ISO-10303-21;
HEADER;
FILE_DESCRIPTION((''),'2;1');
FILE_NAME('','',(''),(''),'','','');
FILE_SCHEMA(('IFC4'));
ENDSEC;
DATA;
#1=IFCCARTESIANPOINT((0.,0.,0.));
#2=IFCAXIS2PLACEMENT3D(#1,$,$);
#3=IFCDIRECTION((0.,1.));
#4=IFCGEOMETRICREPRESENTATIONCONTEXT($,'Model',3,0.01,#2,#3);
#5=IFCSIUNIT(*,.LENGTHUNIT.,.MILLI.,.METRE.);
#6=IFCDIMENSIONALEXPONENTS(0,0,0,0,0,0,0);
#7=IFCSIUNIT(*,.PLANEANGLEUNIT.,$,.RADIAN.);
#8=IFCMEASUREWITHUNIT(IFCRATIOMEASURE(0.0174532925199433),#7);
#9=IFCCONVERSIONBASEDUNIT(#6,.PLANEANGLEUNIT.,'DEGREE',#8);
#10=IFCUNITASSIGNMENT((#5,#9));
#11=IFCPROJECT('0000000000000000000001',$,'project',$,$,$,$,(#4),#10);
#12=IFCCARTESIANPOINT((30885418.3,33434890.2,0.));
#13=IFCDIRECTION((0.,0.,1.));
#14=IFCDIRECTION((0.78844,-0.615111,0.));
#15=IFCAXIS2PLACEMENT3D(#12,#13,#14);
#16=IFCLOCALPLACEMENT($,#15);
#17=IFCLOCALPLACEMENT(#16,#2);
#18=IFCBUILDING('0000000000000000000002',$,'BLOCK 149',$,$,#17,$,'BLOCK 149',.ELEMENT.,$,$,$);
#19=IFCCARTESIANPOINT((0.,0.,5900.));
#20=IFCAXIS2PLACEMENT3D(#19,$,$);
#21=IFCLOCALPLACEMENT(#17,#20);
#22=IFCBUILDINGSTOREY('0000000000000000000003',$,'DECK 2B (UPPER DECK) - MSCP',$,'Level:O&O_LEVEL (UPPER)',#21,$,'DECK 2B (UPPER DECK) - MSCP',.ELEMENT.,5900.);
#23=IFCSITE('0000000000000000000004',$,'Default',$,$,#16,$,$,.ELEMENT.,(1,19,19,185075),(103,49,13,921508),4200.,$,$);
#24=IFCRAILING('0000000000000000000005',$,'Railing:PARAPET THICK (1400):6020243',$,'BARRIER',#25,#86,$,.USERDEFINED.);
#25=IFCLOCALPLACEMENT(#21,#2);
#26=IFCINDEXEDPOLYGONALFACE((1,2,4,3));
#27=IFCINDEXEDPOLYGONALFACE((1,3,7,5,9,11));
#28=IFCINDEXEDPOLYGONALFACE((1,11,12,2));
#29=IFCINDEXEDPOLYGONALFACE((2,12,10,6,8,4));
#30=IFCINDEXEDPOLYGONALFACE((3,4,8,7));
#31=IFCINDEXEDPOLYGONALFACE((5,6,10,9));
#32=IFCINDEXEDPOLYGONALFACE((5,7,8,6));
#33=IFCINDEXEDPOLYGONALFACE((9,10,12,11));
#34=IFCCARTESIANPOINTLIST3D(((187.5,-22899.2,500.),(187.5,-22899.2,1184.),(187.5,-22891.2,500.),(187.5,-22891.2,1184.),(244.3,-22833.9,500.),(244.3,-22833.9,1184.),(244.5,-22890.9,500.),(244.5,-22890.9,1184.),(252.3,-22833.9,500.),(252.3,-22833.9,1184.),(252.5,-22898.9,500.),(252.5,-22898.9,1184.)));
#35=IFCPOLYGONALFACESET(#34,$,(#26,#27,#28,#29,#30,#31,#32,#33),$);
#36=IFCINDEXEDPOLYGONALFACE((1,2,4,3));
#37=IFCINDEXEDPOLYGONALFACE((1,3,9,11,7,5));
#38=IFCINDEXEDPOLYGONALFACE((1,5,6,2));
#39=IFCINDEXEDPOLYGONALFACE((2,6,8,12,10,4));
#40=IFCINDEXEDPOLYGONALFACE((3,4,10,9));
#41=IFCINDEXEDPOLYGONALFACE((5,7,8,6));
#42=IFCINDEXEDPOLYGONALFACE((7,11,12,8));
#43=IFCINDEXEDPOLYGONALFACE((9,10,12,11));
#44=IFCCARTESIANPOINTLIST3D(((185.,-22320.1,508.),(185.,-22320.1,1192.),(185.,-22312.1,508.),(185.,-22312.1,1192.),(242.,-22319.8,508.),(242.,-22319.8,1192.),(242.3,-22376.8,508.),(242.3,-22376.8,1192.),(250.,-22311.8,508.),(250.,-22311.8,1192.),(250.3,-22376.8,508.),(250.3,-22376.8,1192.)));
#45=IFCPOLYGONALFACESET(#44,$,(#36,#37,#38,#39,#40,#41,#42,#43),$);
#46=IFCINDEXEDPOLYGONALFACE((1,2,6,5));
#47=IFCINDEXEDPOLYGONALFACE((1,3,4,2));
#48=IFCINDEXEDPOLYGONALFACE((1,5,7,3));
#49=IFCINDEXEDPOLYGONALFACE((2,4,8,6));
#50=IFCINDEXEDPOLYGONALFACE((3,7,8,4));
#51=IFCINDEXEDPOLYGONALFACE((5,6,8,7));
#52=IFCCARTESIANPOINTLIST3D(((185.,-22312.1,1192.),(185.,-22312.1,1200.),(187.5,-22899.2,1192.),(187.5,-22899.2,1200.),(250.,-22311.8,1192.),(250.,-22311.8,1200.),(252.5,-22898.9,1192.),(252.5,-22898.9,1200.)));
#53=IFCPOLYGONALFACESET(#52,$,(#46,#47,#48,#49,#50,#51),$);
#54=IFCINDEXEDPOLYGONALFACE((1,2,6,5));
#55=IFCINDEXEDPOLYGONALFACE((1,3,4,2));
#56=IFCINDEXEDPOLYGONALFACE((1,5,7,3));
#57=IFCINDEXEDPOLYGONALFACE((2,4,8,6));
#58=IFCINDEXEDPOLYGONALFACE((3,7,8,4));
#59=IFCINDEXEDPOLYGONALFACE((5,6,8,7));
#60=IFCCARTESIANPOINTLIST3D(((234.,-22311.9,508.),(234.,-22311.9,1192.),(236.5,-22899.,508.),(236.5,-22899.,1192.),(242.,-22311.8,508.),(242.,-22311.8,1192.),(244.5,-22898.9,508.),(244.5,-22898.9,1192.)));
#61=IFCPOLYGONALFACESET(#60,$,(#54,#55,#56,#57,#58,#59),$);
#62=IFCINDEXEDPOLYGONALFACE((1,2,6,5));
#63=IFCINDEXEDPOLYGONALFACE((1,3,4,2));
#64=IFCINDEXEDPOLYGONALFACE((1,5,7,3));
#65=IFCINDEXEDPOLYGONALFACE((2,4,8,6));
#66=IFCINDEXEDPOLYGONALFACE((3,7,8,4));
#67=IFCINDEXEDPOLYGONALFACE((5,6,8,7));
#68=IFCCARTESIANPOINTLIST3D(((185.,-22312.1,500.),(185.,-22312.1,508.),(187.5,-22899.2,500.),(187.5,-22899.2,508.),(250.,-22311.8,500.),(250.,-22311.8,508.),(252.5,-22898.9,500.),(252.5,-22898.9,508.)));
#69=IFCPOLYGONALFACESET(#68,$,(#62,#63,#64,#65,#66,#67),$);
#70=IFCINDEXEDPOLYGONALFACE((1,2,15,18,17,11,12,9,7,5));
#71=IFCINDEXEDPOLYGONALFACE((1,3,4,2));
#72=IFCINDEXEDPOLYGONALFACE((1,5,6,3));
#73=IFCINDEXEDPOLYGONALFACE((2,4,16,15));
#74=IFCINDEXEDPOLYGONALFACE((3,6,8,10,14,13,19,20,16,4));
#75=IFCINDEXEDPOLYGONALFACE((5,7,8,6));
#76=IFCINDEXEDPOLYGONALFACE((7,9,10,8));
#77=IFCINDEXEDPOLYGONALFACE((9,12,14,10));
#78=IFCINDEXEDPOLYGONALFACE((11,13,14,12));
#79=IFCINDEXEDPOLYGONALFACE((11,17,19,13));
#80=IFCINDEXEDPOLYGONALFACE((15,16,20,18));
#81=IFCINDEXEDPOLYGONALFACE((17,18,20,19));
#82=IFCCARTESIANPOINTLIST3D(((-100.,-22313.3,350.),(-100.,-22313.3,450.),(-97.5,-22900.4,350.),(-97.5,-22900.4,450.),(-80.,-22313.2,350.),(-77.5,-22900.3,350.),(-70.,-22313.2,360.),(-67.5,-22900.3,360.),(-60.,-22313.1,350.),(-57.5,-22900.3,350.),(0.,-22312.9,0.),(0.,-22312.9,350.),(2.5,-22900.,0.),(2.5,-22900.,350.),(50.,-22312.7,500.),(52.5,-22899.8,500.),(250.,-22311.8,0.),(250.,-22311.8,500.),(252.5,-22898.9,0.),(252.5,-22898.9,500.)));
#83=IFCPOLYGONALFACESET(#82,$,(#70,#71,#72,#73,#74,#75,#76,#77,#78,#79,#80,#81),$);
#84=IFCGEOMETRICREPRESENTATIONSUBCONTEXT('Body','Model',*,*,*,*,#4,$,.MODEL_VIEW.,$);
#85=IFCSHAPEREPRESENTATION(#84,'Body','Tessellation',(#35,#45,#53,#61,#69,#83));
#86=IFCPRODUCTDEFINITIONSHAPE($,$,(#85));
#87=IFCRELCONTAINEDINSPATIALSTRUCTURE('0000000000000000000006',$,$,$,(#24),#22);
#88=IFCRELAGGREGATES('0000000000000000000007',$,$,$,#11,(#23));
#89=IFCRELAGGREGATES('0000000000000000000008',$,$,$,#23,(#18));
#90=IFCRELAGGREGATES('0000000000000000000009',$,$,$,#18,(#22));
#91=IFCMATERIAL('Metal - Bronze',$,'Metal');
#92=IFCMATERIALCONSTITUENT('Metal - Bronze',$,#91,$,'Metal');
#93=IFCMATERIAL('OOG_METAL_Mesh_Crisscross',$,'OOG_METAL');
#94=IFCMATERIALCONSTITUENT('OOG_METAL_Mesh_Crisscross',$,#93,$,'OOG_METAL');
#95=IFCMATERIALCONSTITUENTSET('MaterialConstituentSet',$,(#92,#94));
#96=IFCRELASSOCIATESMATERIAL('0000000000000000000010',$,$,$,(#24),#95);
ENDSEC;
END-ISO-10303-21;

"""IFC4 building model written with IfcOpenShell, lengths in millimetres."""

from ifc_helpers import new_model, entity, si_unit, converted_unit, direction, frame, origin, place, context, subcontext, project, spatial, indexed_curve, outline, extrude, material, constituent, constituent_set, element, save


model = new_model("IFC4")

# Units and contexts
model_context = context("Model", 3, precision=0.01, world=origin(), true_north=direction((0.0, 1.0)))
body_context = subcontext(model_context, "Body", "Model", "MODEL_VIEW")
ifc_project = project(units=[si_unit("LENGTHUNIT", "METRE", prefix="MILLI"), converted_unit("PLANEANGLEUNIT", "DEGREE", entity("IfcRatioMeasure", 0.0174532925199433), si_unit("PLANEANGLEUNIT", "RADIAN"), dimensions=[0, 0, 0, 0, 0, 0, 0])], contexts=[model_context])

# Site, building, storey
site_placement = place(None, frame((30885418.3, 33434890.2, 0.0), z_axis=(0.0, 0.0, 1.0), x_axis=(0.78844, -0.615111, 0.0)))
site = spatial("IfcSite", under=ifc_project, at=site_placement, Name="Default", CompositionType="ELEMENT", RefLatitude=(1, 19, 19, 185075), RefLongitude=(103, 49, 13, 921508), RefElevation=4200.0)
building_placement = place(site_placement, origin())
building = spatial("IfcBuilding", under=site, at=building_placement, Name="BLOCK 149", LongName="BLOCK 149", CompositionType="ELEMENT")
storey_placement = place(building_placement, frame((0.0, 0.0, 5900.0)))
storey = spatial("IfcBuildingStorey", under=building, at=storey_placement, Name="DECK 2B (UPPER DECK) - MSCP", ObjectType="Level:O&O_LEVEL (UPPER)", LongName="DECK 2B (UPPER DECK) - MSCP", CompositionType="ELEMENT", Elevation=5900.0)

# Railing
ifc_material_1 = material(Name="Metal - Bronze", Category="Metal")
ifc_material_2 = material(Name="OOG_METAL_Mesh_Crisscross", Category="OOG_METAL")
ifc_constituent_1 = constituent(ifc_material_1, Name="Metal - Bronze", Category="Metal")
ifc_constituent_2 = constituent(ifc_material_2, Name="OOG_METAL_Mesh_Crisscross", Category="OOG_METAL")
ifc_constituent_set_1 = constituent_set(constituents=[ifc_constituent_1, ifc_constituent_2], Name="MaterialConstituentSet")
railing_1_placement = place(storey_placement, origin())
element("IfcRailing", 1, at=railing_1_placement, inside=storey, material=ifc_constituent_set_1, Name="Railing:PARAPET THICK (1400):6020243", ObjectType="BARRIER", PredefinedType="USERDEFINED", context=body_context, shape_type="SweptSolid", body=[
    extrude(outline(indexed_curve([(16.3, -40.7), (24.3, -40.7), (24.3, 24.3), (-40.7, 24.3), (-40.7, 16.3), (16.3, 16.3), (16.3, -40.7)], self_intersect=False)), frame((228.1, -22874.7, 500.0), z_axis=(0.0, 0.0, 1.0), x_axis=(0.004384, -0.99999, 0.0)), (0.0, 0.0, 1.0), 684.0),
    extrude(outline(indexed_curve([(-40.7, -16.3), (-40.7, -24.3), (24.3, -24.3), (24.3, 40.7), (16.3, 40.7), (16.3, -16.3), (-40.7, -16.3)], self_intersect=False)), frame((225.7, -22336.2, 508.0), z_axis=(0.0, 0.0, -1.0), x_axis=(0.99999, 0.004384, 0.0)), (0.0, 0.0, -1.0), 684.0),
    extrude(outline(indexed_curve([(-293.6, -32.5), (293.6, -32.5), (293.6, 32.5), (-293.6, 32.5), (-293.6, -32.5)], self_intersect=False)), frame((218.8, -22605.5, 1192.0), z_axis=(0.0, 0.0, 1.0), x_axis=(0.004384, -0.99999, 0.0)), (0.0, 0.0, 1.0), 8.0),
    extrude(outline(indexed_curve([(-293.6, -4.0), (293.6, -4.0), (293.6, 4.0), (-293.6, 4.0), (-293.6, -4.0)], self_intersect=False)), frame((239.3, -22605.4, 508.0), z_axis=(0.0, 0.0, 1.0), x_axis=(0.004384, -0.99999, 0.0)), (0.0, 0.0, 1.0), 684.0),
    extrude(outline(indexed_curve([(-293.6, -32.5), (293.6, -32.5), (293.6, 32.5), (-293.6, 32.5), (-293.6, -32.5)], self_intersect=False)), frame((218.8, -22605.5, 500.0), z_axis=(0.0, 0.0, 1.0), x_axis=(0.004384, -0.99999, 0.0)), (0.0, 0.0, 1.0), 8.0),
    extrude(outline(indexed_curve([(-321.0, 14.0), (-321.0, -236.0), (179.0, -236.0), (179.0, -36.0), (129.0, 114.0), (29.0, 114.0), (29.0, 94.0), (39.0, 84.0), (29.0, 74.0), (29.0, 14.0), (-321.0, 14.0)], self_intersect=False)), frame((16.5, -22899.9, 321.0), z_axis=(0.004384, -0.99999, 0.0), x_axis=(0.0, 0.0, 1.0)), (0.0, 0.0, -1.0), 587.1),
])

save(model, "model.ifc")
